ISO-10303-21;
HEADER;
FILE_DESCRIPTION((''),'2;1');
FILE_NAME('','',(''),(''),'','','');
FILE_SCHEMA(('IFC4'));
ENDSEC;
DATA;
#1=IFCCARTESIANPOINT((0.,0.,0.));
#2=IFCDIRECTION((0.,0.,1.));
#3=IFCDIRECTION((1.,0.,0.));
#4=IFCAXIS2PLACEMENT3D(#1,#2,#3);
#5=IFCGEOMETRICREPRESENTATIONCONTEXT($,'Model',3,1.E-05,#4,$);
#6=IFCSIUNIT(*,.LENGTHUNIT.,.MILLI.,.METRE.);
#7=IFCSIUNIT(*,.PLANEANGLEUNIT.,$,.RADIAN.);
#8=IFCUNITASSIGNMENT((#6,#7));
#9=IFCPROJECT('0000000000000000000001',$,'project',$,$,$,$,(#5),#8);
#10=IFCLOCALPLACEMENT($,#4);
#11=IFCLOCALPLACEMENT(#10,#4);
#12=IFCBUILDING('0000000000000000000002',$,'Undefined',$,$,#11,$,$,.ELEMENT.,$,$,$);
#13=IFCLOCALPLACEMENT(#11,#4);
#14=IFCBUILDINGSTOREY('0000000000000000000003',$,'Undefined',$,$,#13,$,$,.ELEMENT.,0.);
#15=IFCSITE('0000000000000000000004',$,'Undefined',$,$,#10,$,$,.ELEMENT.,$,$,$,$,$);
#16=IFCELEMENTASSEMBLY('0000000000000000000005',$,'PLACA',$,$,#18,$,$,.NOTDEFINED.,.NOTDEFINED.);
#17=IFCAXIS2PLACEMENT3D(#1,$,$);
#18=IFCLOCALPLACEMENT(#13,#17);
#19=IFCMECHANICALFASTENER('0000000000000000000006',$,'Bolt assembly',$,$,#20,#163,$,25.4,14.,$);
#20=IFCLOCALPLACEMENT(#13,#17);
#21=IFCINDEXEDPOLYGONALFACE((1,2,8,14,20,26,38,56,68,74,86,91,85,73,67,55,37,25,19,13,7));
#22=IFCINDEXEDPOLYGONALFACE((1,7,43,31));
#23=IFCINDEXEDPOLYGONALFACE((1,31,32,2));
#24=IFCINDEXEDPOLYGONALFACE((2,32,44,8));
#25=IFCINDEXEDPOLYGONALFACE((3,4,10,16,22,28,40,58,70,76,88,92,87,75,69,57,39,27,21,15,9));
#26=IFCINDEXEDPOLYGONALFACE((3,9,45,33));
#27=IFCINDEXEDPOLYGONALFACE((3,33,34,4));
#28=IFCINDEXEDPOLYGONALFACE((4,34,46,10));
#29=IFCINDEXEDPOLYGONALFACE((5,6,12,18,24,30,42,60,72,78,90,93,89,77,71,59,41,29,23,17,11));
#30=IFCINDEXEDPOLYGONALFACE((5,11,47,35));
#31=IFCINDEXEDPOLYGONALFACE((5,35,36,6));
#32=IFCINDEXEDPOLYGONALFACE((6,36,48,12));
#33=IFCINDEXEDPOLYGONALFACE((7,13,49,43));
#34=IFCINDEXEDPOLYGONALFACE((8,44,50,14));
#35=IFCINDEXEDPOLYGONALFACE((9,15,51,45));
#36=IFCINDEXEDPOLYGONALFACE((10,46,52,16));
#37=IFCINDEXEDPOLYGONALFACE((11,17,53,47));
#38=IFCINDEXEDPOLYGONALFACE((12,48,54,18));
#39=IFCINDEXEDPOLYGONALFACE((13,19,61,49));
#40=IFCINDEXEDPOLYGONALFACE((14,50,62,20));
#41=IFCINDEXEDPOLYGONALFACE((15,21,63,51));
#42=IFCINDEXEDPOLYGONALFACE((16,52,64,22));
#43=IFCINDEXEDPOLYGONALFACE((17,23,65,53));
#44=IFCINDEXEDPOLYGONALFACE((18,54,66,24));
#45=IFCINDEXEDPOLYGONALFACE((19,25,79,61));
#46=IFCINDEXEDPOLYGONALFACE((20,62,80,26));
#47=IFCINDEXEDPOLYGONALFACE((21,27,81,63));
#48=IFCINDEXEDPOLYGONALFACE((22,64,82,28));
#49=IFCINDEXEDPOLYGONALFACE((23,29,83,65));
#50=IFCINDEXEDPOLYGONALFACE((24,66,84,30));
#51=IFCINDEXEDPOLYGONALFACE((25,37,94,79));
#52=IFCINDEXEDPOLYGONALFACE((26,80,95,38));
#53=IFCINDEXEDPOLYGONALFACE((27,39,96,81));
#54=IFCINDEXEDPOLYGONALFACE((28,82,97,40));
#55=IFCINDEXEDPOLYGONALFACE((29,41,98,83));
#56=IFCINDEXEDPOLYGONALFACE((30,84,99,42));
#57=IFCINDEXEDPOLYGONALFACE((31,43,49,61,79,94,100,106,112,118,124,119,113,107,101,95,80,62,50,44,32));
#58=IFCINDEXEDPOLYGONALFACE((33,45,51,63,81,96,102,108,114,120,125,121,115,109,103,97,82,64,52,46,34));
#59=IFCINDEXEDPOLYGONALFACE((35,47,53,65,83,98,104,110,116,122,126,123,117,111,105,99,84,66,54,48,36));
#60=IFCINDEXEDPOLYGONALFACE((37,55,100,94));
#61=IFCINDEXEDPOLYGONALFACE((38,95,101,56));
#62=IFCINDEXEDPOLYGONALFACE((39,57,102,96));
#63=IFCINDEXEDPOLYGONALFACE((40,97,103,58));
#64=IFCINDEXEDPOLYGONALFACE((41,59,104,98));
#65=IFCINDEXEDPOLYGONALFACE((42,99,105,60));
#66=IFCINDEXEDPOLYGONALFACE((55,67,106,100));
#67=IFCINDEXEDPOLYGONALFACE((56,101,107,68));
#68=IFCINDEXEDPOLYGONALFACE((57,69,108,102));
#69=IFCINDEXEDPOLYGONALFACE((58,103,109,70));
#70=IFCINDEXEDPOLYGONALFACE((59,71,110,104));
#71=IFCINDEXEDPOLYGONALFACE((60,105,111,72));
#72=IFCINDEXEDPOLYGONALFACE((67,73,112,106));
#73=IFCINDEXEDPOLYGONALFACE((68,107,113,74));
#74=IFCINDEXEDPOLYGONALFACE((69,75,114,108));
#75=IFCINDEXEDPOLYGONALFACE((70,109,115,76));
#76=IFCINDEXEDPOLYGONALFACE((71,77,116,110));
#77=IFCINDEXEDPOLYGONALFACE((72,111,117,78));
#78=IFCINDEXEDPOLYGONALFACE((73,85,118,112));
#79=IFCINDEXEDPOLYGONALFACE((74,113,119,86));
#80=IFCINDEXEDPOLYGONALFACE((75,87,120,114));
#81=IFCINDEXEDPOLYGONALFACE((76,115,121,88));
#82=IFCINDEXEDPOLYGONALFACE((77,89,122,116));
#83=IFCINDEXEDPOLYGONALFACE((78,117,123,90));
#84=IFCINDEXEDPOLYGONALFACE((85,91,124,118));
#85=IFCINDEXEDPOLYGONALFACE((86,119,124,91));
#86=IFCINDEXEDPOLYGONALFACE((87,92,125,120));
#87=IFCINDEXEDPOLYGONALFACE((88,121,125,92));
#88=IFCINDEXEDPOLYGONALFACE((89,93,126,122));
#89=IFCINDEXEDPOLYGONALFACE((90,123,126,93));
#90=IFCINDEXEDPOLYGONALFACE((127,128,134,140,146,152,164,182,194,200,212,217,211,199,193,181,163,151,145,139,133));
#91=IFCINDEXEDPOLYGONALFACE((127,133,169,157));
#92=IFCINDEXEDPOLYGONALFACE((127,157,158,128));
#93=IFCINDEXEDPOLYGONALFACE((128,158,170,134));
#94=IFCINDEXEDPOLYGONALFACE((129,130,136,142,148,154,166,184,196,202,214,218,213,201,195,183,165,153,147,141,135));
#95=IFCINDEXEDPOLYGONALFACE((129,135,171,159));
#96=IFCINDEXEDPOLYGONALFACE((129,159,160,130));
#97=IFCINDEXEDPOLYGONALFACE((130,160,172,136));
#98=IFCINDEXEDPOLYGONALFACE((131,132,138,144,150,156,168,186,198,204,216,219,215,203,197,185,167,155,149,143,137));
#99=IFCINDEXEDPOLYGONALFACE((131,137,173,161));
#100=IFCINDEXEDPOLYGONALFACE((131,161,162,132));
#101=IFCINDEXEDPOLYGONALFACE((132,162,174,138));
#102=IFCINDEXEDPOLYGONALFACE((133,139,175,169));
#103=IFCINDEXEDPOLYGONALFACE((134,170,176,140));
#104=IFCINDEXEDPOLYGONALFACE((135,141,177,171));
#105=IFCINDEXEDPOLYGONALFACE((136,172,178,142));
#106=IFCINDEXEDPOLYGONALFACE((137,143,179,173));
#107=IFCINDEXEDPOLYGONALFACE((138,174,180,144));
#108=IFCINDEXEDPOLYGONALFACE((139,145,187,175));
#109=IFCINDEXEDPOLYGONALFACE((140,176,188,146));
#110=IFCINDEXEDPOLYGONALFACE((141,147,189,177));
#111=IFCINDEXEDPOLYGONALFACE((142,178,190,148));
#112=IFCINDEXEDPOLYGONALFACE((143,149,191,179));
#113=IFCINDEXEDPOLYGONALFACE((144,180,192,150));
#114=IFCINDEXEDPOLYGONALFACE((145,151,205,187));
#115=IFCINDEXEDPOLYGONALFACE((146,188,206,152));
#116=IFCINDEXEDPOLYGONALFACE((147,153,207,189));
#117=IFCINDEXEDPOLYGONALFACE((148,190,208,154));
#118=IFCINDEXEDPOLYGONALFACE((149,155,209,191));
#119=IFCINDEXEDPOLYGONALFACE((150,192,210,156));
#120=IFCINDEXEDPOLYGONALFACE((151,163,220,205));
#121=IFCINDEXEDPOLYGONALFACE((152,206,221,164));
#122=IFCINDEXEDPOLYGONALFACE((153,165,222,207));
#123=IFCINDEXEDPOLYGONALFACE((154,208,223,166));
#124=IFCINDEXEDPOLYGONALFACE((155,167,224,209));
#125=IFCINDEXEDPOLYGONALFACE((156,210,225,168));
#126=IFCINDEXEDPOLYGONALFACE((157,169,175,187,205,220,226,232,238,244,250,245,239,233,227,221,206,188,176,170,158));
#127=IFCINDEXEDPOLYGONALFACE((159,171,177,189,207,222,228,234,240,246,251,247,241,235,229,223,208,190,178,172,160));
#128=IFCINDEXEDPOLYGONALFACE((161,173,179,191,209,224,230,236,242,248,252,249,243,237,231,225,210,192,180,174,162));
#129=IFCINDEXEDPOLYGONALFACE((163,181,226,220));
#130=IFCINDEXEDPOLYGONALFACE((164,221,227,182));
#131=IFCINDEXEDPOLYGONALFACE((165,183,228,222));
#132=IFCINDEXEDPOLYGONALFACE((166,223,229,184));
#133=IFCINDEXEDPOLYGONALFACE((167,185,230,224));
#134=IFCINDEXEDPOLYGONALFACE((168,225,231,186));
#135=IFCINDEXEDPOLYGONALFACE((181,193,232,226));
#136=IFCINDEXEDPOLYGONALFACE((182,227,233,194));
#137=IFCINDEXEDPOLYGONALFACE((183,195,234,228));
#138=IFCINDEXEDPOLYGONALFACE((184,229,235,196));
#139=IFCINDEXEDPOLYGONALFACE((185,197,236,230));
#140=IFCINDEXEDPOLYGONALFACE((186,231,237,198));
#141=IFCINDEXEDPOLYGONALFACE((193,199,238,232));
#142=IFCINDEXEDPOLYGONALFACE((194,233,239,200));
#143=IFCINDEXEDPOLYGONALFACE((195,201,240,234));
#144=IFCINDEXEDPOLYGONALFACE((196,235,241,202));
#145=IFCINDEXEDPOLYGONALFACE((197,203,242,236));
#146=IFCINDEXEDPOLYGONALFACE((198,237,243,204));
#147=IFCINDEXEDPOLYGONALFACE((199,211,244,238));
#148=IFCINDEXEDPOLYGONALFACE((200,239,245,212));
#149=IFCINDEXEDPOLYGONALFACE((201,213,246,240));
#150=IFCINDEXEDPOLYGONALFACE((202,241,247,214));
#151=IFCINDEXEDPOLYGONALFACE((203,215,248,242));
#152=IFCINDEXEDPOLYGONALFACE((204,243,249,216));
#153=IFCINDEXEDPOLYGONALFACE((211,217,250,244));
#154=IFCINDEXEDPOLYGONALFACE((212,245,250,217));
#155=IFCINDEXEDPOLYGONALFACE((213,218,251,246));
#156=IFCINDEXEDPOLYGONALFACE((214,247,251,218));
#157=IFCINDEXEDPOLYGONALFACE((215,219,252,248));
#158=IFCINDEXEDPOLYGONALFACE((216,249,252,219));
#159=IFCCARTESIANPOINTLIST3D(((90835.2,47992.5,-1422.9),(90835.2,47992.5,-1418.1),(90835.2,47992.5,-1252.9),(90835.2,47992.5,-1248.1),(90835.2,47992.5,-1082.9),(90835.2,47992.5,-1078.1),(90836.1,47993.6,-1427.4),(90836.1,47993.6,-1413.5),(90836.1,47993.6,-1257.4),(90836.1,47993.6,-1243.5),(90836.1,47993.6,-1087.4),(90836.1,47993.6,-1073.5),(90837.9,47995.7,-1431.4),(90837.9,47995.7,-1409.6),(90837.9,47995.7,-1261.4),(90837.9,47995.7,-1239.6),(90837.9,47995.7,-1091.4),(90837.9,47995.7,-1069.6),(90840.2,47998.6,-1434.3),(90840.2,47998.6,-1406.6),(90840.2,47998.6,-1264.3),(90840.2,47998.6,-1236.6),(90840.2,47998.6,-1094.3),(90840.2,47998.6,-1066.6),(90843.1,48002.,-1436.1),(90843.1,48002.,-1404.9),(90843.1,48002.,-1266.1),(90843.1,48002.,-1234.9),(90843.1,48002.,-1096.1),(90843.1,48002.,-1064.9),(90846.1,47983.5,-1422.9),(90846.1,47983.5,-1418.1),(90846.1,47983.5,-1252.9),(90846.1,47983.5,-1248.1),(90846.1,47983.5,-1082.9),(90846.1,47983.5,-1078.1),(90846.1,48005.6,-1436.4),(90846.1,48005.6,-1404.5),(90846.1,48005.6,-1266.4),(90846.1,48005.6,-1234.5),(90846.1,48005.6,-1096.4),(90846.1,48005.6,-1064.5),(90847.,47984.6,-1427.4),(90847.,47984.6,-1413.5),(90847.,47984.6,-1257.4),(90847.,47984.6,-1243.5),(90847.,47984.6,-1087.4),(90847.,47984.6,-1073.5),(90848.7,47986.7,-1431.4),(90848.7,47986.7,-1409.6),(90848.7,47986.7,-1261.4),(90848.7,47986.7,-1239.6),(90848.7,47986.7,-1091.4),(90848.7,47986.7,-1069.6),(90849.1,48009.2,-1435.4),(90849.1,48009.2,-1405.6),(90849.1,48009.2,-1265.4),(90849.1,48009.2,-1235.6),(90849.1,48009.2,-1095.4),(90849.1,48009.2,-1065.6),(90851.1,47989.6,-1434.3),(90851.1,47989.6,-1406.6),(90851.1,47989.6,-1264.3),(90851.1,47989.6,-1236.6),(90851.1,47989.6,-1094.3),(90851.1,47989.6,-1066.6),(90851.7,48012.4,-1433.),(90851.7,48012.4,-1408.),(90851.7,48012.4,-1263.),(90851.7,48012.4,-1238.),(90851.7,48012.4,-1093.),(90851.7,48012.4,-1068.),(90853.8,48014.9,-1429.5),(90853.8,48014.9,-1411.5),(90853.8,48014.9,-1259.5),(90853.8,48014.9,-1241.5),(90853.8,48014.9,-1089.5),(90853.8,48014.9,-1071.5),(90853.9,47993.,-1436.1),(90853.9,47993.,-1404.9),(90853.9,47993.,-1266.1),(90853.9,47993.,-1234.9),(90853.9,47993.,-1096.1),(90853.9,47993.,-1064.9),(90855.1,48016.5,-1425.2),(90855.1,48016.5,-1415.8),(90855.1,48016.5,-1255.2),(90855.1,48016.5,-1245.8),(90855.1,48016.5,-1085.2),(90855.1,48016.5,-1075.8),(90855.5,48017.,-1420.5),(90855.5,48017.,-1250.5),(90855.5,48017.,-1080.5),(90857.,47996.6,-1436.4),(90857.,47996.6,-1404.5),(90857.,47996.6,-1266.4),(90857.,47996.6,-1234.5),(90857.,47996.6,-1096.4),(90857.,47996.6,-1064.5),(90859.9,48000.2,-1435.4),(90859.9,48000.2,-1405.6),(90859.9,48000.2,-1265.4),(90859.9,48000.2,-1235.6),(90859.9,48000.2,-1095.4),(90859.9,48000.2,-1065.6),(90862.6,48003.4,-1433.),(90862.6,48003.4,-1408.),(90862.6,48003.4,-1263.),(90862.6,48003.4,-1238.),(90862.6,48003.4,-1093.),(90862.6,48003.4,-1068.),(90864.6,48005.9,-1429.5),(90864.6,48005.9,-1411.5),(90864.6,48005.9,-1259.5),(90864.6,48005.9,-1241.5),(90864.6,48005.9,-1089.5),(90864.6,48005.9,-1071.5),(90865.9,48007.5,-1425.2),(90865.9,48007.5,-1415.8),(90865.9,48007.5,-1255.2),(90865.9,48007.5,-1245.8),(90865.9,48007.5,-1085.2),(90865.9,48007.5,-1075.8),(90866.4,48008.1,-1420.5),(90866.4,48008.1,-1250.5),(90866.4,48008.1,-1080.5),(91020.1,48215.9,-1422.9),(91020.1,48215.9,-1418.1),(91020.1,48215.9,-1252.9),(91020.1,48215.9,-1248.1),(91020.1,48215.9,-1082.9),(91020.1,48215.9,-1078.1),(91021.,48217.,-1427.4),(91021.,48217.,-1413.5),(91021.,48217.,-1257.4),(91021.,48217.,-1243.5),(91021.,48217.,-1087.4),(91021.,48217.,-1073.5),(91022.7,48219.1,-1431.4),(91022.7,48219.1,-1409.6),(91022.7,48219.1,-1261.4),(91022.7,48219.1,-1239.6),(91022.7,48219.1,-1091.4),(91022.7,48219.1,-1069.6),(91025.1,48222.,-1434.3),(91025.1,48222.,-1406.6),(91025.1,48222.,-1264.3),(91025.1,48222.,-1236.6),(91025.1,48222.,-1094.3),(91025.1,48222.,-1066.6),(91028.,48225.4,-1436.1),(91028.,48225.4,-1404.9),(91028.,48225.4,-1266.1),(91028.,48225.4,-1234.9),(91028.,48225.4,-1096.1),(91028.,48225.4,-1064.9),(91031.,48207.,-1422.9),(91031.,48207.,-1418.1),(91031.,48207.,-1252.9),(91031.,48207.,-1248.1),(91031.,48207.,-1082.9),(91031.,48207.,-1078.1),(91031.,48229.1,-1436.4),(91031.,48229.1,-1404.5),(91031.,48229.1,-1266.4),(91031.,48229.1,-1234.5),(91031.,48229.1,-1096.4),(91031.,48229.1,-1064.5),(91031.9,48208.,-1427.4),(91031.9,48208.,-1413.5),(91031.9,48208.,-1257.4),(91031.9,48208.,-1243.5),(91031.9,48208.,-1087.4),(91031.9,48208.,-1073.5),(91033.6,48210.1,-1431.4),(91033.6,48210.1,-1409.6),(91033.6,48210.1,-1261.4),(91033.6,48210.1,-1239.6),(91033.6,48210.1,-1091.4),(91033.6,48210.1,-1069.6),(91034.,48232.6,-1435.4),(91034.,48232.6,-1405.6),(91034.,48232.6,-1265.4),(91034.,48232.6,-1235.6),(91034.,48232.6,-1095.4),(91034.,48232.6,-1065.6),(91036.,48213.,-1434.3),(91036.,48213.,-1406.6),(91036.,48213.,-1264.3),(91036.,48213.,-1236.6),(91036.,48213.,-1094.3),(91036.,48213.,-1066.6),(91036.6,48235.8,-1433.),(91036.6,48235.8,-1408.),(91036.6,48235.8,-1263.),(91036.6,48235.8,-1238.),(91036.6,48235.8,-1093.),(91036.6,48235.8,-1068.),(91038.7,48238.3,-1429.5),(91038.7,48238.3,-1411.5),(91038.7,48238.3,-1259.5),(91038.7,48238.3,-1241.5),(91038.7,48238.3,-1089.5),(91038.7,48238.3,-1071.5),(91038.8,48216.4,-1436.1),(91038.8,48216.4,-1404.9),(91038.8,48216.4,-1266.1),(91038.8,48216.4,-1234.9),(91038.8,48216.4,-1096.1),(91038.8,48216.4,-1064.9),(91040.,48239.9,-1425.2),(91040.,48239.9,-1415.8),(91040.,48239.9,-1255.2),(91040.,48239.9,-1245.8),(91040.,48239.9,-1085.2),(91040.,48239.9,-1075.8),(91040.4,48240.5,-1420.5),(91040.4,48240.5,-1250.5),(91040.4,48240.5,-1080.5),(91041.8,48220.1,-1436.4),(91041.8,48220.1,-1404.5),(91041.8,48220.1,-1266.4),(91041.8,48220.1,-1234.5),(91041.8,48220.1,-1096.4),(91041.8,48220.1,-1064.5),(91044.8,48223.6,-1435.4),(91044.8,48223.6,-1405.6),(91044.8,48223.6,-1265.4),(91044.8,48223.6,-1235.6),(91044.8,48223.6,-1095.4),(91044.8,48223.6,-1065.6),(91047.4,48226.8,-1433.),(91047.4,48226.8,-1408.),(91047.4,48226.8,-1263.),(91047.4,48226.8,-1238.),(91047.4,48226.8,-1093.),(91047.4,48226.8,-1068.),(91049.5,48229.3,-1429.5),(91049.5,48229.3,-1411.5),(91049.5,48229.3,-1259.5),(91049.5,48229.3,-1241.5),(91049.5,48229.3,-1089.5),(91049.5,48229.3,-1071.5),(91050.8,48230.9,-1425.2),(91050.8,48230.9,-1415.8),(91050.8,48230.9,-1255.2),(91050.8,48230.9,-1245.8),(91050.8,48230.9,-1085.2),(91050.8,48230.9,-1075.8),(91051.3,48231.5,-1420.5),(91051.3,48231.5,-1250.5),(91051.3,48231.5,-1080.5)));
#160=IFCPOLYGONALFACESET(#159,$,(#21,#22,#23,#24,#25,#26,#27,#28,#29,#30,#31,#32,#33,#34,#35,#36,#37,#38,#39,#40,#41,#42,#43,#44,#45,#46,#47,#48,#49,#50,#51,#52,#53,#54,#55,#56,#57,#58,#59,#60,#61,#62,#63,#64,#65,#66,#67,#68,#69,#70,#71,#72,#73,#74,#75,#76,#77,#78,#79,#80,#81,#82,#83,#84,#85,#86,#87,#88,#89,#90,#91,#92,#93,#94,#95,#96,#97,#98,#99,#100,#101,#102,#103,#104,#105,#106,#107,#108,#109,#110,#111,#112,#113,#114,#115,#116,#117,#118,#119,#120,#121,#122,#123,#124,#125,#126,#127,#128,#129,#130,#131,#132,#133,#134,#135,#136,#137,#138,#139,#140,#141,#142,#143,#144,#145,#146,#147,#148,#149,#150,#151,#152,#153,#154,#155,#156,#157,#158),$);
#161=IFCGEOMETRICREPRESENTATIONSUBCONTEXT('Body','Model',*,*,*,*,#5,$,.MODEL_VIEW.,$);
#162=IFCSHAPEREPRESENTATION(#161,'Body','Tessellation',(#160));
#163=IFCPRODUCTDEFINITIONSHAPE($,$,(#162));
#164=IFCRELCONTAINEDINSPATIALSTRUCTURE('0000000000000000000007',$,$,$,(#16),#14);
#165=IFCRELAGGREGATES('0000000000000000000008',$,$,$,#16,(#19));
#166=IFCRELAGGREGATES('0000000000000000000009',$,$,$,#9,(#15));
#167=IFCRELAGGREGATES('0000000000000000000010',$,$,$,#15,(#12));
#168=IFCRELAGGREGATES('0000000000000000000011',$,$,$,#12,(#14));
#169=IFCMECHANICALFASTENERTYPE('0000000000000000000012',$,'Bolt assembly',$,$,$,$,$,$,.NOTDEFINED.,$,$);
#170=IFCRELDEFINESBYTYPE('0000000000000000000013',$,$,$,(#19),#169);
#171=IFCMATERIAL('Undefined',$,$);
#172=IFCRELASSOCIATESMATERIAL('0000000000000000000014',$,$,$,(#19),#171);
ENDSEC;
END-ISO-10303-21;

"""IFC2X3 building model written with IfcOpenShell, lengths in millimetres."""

from ifc_helpers import new_model, si_unit, frame, origin_with_axes, origin_2d_with_axis, place, context, subcontext, project, spatial, circle, extrude, source, transform, mapped, material, type_object, element, aggregate, save


model = new_model("IFC2X3")

# Units and contexts
model_context = context("Model", 3, precision=1e-05, world=origin_with_axes())
body_context = subcontext(model_context, "Body", "Model", "MODEL_VIEW")
ifc_project = project(units=[si_unit("LENGTHUNIT", "METRE", prefix="MILLI"), si_unit("PLANEANGLEUNIT", "RADIAN")], contexts=[model_context])

# Site, building, storey
site_placement = place(None, origin_with_axes())
site = spatial("IfcSite", under=ifc_project, at=site_placement, Name="Undefined", CompositionType="ELEMENT")
building_placement = place(site_placement, origin_with_axes())
building = spatial("IfcBuilding", under=site, at=building_placement, Name="Undefined", CompositionType="ELEMENT")
storey_placement = place(building_placement, origin_with_axes())
storey = spatial("IfcBuildingStorey", under=building, at=storey_placement, Name="Undefined", CompositionType="ELEMENT", Elevation=0.0)

# Element assembly
assembly_1_placement = place(storey_placement, origin_with_axes())
assembly_1 = element("IfcElementAssembly", 1, at=assembly_1_placement, inside=storey, Name="PLACA", AssemblyPlace="NOTDEFINED", PredefinedType="NOTDEFINED")

# Mechanical fastener
ifc_material_1 = material(Name="Undefined")
mechanical_fastener_type = type_object("IfcMechanicalFastenerType", Name="Bolt assembly")
shared_shape_1 = source(origin_with_axes(), body_context, "Body", "SweptSolid", [
    extrude(circle(Radius=16.0, at=origin_2d_with_axis()), frame((0.0, 0.0, 0.0), z_axis=(0.0, 1.0, 0.0), x_axis=(1.0, 0.0, 0.0)), (0.0, 0.0, 1.0), 14.1),
])
mechanical_fastener_1_placement = place(assembly_1_placement, frame((90856.2, 47995.7, -1250.5), z_axis=(0.000001, 0.000001, 1.0), x_axis=(0.63756, 0.770401, -0.000002)))
mechanical_fastener_1 = element("IfcMechanicalFastener", 2, at=mechanical_fastener_1_placement, type_object=mechanical_fastener_type, material=ifc_material_1, Name="Bolt assembly", NominalDiameter=25.4, NominalLength=14.0, context=body_context, shape_type="MappedRepresentation", body=[
    mapped(shared_shape_1, transform((0.0, 0.0, -170.0))),
    mapped(shared_shape_1, transform((290.0, 0.0, -170.0))),
    mapped(shared_shape_1, transform((0.0, 0.0, 0.0))),
    mapped(shared_shape_1, transform((290.0, 0.0, 0.0))),
    mapped(shared_shape_1, transform((0.0, 0.0, 170.0))),
    mapped(shared_shape_1, transform((290.0, 0.0, 170.0))),
])
aggregate(assembly_1, [mechanical_fastener_1])

save(model, "model.ifc")
